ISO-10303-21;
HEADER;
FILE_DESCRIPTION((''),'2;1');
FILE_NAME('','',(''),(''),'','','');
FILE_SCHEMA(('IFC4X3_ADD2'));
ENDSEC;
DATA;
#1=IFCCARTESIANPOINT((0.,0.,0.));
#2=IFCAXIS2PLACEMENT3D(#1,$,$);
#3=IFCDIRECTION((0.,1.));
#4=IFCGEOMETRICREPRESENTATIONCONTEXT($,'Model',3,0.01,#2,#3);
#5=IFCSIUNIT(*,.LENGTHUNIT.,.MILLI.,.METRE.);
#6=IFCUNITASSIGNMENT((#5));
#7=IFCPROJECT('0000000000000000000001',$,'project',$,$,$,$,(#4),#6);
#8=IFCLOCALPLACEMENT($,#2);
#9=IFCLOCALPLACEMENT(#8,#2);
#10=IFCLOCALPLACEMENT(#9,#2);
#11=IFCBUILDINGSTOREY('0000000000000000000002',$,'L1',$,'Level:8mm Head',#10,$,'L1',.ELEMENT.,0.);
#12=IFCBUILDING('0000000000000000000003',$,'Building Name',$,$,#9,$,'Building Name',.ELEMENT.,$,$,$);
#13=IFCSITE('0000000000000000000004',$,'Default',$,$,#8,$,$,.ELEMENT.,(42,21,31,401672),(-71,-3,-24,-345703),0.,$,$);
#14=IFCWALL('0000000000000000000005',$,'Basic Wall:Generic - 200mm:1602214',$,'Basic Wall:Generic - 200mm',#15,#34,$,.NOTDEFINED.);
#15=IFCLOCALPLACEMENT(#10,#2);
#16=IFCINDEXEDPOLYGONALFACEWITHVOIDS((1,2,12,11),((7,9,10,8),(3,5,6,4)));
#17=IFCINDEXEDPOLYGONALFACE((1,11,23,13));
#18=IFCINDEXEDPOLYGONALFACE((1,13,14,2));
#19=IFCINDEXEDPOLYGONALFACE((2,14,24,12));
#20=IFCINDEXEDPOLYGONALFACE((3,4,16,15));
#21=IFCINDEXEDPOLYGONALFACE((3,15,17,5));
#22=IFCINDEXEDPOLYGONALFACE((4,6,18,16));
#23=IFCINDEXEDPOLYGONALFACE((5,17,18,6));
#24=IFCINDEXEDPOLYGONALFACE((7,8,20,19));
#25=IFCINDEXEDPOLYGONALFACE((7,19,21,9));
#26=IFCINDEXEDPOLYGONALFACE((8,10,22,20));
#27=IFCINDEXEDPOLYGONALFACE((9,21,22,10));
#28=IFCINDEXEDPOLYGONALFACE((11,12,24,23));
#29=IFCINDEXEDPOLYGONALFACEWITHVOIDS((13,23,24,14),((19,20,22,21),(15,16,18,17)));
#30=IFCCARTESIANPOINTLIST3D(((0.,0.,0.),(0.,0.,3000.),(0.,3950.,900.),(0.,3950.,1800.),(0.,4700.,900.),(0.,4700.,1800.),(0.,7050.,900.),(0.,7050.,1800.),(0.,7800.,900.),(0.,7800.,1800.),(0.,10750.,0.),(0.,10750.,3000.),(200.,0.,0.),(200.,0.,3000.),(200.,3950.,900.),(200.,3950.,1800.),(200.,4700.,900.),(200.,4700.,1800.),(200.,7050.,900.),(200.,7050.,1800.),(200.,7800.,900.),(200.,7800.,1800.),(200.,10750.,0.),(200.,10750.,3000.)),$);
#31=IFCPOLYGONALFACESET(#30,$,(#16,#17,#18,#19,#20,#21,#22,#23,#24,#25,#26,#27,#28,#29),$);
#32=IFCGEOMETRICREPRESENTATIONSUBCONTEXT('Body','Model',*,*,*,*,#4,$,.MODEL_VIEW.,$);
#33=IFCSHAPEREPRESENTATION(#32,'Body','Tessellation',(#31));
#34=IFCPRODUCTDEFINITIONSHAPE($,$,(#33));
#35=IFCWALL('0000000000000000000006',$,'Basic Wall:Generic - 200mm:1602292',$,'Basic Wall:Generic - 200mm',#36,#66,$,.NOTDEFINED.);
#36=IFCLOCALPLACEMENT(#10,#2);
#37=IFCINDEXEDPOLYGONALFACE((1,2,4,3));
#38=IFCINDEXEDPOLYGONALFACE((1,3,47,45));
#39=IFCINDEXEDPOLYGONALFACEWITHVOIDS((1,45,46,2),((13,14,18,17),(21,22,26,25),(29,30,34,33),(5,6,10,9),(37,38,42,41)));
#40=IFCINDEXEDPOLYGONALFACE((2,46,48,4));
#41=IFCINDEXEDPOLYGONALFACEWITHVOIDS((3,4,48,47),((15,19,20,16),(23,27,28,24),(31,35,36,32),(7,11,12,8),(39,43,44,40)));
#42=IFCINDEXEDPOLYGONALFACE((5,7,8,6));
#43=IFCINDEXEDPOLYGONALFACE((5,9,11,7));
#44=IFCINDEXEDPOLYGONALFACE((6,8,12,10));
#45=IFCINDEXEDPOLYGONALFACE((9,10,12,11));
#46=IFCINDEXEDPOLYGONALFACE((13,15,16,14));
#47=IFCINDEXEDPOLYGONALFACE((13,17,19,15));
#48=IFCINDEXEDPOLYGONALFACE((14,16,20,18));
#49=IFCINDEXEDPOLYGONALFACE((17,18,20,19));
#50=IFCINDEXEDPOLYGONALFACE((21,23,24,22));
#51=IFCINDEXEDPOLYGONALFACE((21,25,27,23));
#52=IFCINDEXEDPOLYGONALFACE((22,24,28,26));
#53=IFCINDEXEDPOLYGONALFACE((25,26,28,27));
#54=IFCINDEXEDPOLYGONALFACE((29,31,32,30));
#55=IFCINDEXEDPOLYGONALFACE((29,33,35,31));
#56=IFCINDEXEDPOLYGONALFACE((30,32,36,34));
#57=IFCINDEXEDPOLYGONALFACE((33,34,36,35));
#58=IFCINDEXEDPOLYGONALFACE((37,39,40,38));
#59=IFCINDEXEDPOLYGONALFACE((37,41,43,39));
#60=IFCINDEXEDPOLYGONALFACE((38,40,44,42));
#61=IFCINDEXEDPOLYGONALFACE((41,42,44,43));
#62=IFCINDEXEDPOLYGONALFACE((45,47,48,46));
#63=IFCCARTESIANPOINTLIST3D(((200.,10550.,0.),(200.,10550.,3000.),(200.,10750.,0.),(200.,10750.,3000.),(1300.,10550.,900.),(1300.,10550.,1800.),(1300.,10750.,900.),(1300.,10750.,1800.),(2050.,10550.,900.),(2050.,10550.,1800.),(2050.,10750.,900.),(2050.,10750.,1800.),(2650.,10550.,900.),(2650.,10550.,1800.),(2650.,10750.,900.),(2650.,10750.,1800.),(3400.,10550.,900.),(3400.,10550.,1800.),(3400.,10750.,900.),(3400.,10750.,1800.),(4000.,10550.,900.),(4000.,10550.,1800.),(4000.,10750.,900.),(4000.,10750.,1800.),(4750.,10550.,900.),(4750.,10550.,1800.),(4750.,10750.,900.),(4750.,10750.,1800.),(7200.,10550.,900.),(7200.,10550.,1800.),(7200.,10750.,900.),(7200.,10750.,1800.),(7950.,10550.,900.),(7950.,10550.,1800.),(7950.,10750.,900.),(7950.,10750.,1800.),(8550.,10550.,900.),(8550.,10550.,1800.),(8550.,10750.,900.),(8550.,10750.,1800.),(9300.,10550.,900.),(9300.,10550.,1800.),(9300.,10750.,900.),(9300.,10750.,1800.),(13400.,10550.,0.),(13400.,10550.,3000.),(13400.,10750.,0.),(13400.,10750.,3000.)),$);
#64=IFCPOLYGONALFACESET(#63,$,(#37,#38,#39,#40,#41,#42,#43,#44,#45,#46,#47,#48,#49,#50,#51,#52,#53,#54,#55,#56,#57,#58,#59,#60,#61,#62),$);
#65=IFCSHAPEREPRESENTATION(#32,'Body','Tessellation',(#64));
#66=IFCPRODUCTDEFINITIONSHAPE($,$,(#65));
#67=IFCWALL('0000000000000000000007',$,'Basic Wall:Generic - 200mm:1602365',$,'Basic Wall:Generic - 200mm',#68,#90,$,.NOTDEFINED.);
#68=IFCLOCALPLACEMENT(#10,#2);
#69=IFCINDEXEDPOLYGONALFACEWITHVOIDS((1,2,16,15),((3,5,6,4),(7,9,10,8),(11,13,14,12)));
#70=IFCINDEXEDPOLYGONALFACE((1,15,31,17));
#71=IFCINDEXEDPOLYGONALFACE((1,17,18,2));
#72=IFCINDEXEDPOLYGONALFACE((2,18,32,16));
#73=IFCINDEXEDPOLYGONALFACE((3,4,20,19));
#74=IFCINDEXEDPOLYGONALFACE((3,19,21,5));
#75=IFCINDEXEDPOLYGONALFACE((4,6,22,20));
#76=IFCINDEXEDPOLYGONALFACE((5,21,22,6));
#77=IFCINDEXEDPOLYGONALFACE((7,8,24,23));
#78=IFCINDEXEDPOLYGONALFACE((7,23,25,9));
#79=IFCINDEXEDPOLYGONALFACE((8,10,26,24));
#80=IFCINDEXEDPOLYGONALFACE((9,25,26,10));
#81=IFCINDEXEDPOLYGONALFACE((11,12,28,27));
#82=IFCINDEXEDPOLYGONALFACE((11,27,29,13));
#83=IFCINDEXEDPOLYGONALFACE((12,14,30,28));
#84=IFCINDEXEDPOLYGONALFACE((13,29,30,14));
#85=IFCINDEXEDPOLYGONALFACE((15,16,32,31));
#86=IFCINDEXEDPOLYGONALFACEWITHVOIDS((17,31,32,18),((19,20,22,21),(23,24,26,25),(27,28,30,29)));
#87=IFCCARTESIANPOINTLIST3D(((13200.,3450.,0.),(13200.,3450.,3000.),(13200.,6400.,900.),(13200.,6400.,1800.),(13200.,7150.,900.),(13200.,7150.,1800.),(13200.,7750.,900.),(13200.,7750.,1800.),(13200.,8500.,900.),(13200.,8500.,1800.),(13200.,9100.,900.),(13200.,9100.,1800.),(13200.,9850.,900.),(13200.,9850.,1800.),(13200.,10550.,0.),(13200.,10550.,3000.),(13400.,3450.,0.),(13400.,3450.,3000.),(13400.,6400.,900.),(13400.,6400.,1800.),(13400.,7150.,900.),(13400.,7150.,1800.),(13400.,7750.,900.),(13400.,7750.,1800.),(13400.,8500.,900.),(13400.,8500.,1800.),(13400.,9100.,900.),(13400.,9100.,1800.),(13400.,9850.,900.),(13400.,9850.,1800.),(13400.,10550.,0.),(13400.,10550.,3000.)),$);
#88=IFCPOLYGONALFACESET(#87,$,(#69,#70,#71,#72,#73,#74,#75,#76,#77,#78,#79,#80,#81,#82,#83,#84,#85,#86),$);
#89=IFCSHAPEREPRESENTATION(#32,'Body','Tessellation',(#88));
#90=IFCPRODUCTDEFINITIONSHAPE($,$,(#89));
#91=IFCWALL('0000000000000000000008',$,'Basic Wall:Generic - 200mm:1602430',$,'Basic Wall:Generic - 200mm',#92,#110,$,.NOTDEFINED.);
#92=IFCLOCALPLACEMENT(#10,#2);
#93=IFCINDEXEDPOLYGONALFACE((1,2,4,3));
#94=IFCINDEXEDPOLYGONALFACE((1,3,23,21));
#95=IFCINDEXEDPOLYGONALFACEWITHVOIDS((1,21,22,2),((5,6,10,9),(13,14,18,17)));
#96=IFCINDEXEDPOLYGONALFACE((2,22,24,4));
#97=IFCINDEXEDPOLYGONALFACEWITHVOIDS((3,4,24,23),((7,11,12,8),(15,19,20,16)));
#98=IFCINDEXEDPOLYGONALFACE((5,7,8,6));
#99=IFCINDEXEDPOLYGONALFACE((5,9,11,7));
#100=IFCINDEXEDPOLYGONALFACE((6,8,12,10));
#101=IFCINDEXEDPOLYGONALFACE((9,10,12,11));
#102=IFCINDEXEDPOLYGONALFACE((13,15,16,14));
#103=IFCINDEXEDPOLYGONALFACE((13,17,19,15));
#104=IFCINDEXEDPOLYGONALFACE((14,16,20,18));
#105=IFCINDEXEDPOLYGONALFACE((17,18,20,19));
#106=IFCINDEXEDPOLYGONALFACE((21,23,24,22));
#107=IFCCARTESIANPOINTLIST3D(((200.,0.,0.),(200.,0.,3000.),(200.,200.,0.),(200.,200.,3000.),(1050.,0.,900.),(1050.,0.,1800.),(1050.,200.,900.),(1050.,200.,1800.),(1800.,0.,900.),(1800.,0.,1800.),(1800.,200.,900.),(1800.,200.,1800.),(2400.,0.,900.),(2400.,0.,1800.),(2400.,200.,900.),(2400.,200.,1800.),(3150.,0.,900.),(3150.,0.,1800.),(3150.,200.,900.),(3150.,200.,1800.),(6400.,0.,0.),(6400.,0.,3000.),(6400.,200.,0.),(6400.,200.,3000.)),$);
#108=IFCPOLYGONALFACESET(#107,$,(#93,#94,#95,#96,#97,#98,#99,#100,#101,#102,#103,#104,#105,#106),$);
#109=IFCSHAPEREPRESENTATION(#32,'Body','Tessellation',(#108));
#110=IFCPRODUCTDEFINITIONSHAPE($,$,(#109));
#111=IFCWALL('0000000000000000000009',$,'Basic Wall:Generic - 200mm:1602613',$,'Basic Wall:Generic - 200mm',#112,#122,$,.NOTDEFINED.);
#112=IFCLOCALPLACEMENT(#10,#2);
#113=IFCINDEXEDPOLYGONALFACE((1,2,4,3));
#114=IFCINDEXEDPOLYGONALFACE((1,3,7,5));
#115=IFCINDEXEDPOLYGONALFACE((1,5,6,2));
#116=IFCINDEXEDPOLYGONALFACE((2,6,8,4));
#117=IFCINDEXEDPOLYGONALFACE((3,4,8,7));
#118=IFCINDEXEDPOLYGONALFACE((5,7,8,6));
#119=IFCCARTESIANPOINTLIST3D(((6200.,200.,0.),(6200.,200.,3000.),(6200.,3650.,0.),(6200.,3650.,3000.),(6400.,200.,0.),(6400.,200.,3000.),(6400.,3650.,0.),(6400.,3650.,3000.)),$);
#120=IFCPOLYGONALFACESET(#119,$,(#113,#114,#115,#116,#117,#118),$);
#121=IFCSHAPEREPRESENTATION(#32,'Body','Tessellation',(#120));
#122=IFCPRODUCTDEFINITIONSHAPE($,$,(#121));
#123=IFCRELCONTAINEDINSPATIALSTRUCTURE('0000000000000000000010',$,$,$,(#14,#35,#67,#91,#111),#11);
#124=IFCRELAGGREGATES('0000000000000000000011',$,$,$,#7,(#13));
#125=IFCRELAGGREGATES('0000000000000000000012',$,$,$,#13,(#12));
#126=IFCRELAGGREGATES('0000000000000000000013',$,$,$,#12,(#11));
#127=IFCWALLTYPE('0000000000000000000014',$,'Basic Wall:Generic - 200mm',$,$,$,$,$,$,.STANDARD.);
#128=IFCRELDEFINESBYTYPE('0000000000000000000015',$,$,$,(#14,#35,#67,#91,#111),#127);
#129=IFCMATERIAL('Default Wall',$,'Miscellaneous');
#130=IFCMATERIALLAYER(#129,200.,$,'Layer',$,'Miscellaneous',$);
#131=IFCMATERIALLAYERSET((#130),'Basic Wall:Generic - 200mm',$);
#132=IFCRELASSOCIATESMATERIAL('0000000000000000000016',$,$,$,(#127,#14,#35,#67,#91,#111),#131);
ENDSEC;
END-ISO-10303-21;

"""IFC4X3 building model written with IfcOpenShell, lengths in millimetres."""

from ifc_helpers import new_model, si_unit, direction, frame, frame_2d, origin, place, context, subcontext, project, spatial, rectangle, extrude, material, layer, layer_set, type_object, element, save


model = new_model("IFC4X3")

# Units and contexts
model_context = context("Model", 3, precision=0.01, world=origin(), true_north=direction((0.0, 1.0)))
body_context = subcontext(model_context, "Body", "Model", "MODEL_VIEW")
ifc_project = project(units=[si_unit("LENGTHUNIT", "METRE", prefix="MILLI")], contexts=[model_context])

# Site, building, storey
site_placement = place(None, origin())
site = spatial("IfcSite", under=ifc_project, at=site_placement, Name="Default", CompositionType="ELEMENT", RefLatitude=(42, 21, 31, 401672), RefLongitude=(-71, -3, -24, -345703), RefElevation=0.0)
building_placement = place(site_placement, origin())
building = spatial("IfcBuilding", under=site, at=building_placement, Name="Building Name", LongName="Building Name", CompositionType="ELEMENT")
storey_placement = place(building_placement, origin())
storey = spatial("IfcBuildingStorey", under=building, at=storey_placement, Name="L1", ObjectType="Level:8mm Head", LongName="L1", CompositionType="ELEMENT", Elevation=0.0)

# Walls, openings
ifc_material = material(Name="Default Wall", Category="Miscellaneous")
ifc_layer = layer(ifc_material, 200.0, Name="Layer", Category="Miscellaneous")
ifc_layer_set = layer_set([ifc_layer], Name="Basic Wall:Generic - 200mm")
wall_type = type_object("IfcWallType", Name="Basic Wall:Generic - 200mm", PredefinedType="STANDARD", material=ifc_layer_set)
wall_1_placement = place(storey_placement, frame((100.0, 0.0, 0.0), z_axis=(0.0, 0.0, 1.0), x_axis=(0.0, 1.0, 0.0)))
wall_1 = element("IfcWall", 1, at=wall_1_placement, inside=storey, type_object=wall_type, material=ifc_layer_set, Name="Basic Wall:Generic - 200mm:1602214", ObjectType="Basic Wall:Generic - 200mm", PredefinedType="NOTDEFINED", context=body_context, shape_type="SweptSolid", body=[
    extrude(rectangle(XDim=10750.0, YDim=200.0, at=frame_2d((5375.0, 0.0), x_axis=(-1.0, 0.0))), origin(), (0.0, 0.0, 1.0), 3000.0),
])
opening_1_placement = place(wall_1_placement, frame((3950.0, -100.0, 900.0)))
element("IfcOpeningElement", 2, at=opening_1_placement, cuts=wall_1, PredefinedType="OPENING", context=body_context, shape_type="SweptSolid", body=[
    extrude(rectangle(XDim=900.0, YDim=750.0, at=frame_2d((450.0, 375.0), x_axis=(-1.0, 0.0))), frame((0.0, 0.0, 0.0), z_axis=(0.0, 1.0, 0.0), x_axis=(0.0, 0.0, 1.0)), (0.0, 0.0, 1.0), 200.0),
])
opening_2_placement = place(wall_1_placement, frame((7050.0, -100.0, 900.0)))
element("IfcOpeningElement", 3, at=opening_2_placement, cuts=wall_1, PredefinedType="OPENING", context=body_context, shape_type="SweptSolid", body=[
    extrude(rectangle(XDim=900.0, YDim=750.0, at=frame_2d((450.0, 375.0), x_axis=(-1.0, 0.0))), frame((0.0, 0.0, 0.0), z_axis=(0.0, 1.0, 0.0), x_axis=(0.0, 0.0, 1.0)), (0.0, 0.0, 1.0), 200.0),
])
wall_2_placement = place(storey_placement, frame((200.0, 10650.0, 0.0)))
wall_2 = element("IfcWall", 4, at=wall_2_placement, inside=storey, type_object=wall_type, material=ifc_layer_set, Name="Basic Wall:Generic - 200mm:1602292", ObjectType="Basic Wall:Generic - 200mm", PredefinedType="NOTDEFINED", context=body_context, shape_type="SweptSolid", body=[
    extrude(rectangle(XDim=13200.0, YDim=200.0, at=frame_2d((6600.0, 0.0), x_axis=(-1.0, 0.0))), origin(), (0.0, 0.0, 1.0), 3000.0),
])
opening_3_placement = place(wall_2_placement, frame((1100.0, -100.0, 900.0)))
element("IfcOpeningElement", 5, at=opening_3_placement, cuts=wall_2, PredefinedType="OPENING", context=body_context, shape_type="SweptSolid", body=[
    extrude(rectangle(XDim=900.0, YDim=750.0, at=frame_2d((450.0, 375.0), x_axis=(-1.0, 0.0))), frame((0.0, 0.0, 0.0), z_axis=(0.0, 1.0, 0.0), x_axis=(0.0, 0.0, 1.0)), (0.0, 0.0, 1.0), 200.0),
])
opening_4_placement = place(wall_2_placement, frame((2450.0, -100.0, 900.0)))
element("IfcOpeningElement", 6, at=opening_4_placement, cuts=wall_2, PredefinedType="OPENING", context=body_context, shape_type="SweptSolid", body=[
    extrude(rectangle(XDim=900.0, YDim=750.0, at=frame_2d((450.0, 375.0), x_axis=(-1.0, 0.0))), frame((0.0, 0.0, 0.0), z_axis=(0.0, 1.0, 0.0), x_axis=(0.0, 0.0, 1.0)), (0.0, 0.0, 1.0), 200.0),
])
opening_5_placement = place(wall_2_placement, frame((3800.0, -100.0, 900.0)))
element("IfcOpeningElement", 7, at=opening_5_placement, cuts=wall_2, PredefinedType="OPENING", context=body_context, shape_type="SweptSolid", body=[
    extrude(rectangle(XDim=900.0, YDim=750.0, at=frame_2d((450.0, 375.0), x_axis=(-1.0, 0.0))), frame((0.0, 0.0, 0.0), z_axis=(0.0, 1.0, 0.0), x_axis=(0.0, 0.0, 1.0)), (0.0, 0.0, 1.0), 200.0),
])
opening_6_placement = place(wall_2_placement, frame((7000.0, -100.0, 900.0)))
element("IfcOpeningElement", 8, at=opening_6_placement, cuts=wall_2, PredefinedType="OPENING", context=body_context, shape_type="SweptSolid", body=[
    extrude(rectangle(XDim=900.0, YDim=750.0, at=frame_2d((450.0, 375.0), x_axis=(-1.0, 0.0))), frame((0.0, 0.0, 0.0), z_axis=(0.0, 1.0, 0.0), x_axis=(0.0, 0.0, 1.0)), (0.0, 0.0, 1.0), 200.0),
])
opening_7_placement = place(wall_2_placement, frame((8350.0, -100.0, 900.0)))
element("IfcOpeningElement", 9, at=opening_7_placement, cuts=wall_2, PredefinedType="OPENING", context=body_context, shape_type="SweptSolid", body=[
    extrude(rectangle(XDim=900.0, YDim=750.0, at=frame_2d((450.0, 375.0), x_axis=(-1.0, 0.0))), frame((0.0, 0.0, 0.0), z_axis=(0.0, 1.0, 0.0), x_axis=(0.0, 0.0, 1.0)), (0.0, 0.0, 1.0), 200.0),
])
wall_3_placement = place(storey_placement, frame((13300.0, 10550.0, 0.0), z_axis=(0.0, 0.0, 1.0), x_axis=(0.0, -1.0, 0.0)))
wall_3 = element("IfcWall", 10, at=wall_3_placement, inside=storey, type_object=wall_type, material=ifc_layer_set, Name="Basic Wall:Generic - 200mm:1602365", ObjectType="Basic Wall:Generic - 200mm", PredefinedType="NOTDEFINED", context=body_context, shape_type="SweptSolid", body=[
    extrude(rectangle(XDim=7100.0, YDim=200.0, at=frame_2d((3550.0, 0.0), x_axis=(-1.0, 0.0))), origin(), (0.0, 0.0, 1.0), 3000.0),
])
opening_8_placement = place(wall_3_placement, frame((700.0, -100.0, 900.0)))
element("IfcOpeningElement", 11, at=opening_8_placement, cuts=wall_3, PredefinedType="OPENING", context=body_context, shape_type="SweptSolid", body=[
    extrude(rectangle(XDim=900.0, YDim=750.0, at=frame_2d((450.0, 375.0), x_axis=(-1.0, 0.0))), frame((0.0, 0.0, 0.0), z_axis=(0.0, 1.0, 0.0), x_axis=(0.0, 0.0, 1.0)), (0.0, 0.0, 1.0), 200.0),
])
opening_9_placement = place(wall_3_placement, frame((2050.0, -100.0, 900.0)))
element("IfcOpeningElement", 12, at=opening_9_placement, cuts=wall_3, PredefinedType="OPENING", context=body_context, shape_type="SweptSolid", body=[
    extrude(rectangle(XDim=900.0, YDim=750.0, at=frame_2d((450.0, 375.0), x_axis=(-1.0, 0.0))), frame((0.0, 0.0, 0.0), z_axis=(0.0, 1.0, 0.0), x_axis=(0.0, 0.0, 1.0)), (0.0, 0.0, 1.0), 200.0),
])
opening_10_placement = place(wall_3_placement, frame((3400.0, -100.0, 900.0)))
element("IfcOpeningElement", 13, at=opening_10_placement, cuts=wall_3, PredefinedType="OPENING", context=body_context, shape_type="SweptSolid", body=[
    extrude(rectangle(XDim=900.0, YDim=750.0, at=frame_2d((450.0, 375.0), x_axis=(-1.0, 0.0))), frame((0.0, 0.0, 0.0), z_axis=(0.0, 1.0, 0.0), x_axis=(0.0, 0.0, 1.0)), (0.0, 0.0, 1.0), 200.0),
])
wall_4_placement = place(storey_placement, frame((6400.0, 100.0, 0.0), z_axis=(0.0, 0.0, 1.0), x_axis=(-1.0, 0.0, 0.0)))
wall_4 = element("IfcWall", 14, at=wall_4_placement, inside=storey, type_object=wall_type, material=ifc_layer_set, Name="Basic Wall:Generic - 200mm:1602430", ObjectType="Basic Wall:Generic - 200mm", PredefinedType="NOTDEFINED", context=body_context, shape_type="SweptSolid", body=[
    extrude(rectangle(XDim=6200.0, YDim=200.0, at=frame_2d((3100.0, 0.0), x_axis=(-1.0, 0.0))), origin(), (0.0, 0.0, 1.0), 3000.0),
])
opening_11_placement = place(wall_4_placement, frame((3250.0, -100.0, 900.0)))
element("IfcOpeningElement", 15, at=opening_11_placement, cuts=wall_4, PredefinedType="OPENING", context=body_context, shape_type="SweptSolid", body=[
    extrude(rectangle(XDim=900.0, YDim=750.0, at=frame_2d((450.0, 375.0), x_axis=(-1.0, 0.0))), frame((0.0, 0.0, 0.0), z_axis=(0.0, 1.0, 0.0), x_axis=(0.0, 0.0, 1.0)), (0.0, 0.0, 1.0), 200.0),
])
opening_12_placement = place(wall_4_placement, frame((4600.0, -100.0, 900.0)))
element("IfcOpeningElement", 16, at=opening_12_placement, cuts=wall_4, PredefinedType="OPENING", context=body_context, shape_type="SweptSolid", body=[
    extrude(rectangle(XDim=900.0, YDim=750.0, at=frame_2d((450.0, 375.0), x_axis=(-1.0, 0.0))), frame((0.0, 0.0, 0.0), z_axis=(0.0, 1.0, 0.0), x_axis=(0.0, 0.0, 1.0)), (0.0, 0.0, 1.0), 200.0),
])

# Wall
wall_5_placement = place(storey_placement, frame((6300.0, 200.0, 0.0), z_axis=(0.0, 0.0, 1.0), x_axis=(0.0, 1.0, 0.0)))
element("IfcWall", 17, at=wall_5_placement, inside=storey, type_object=wall_type, material=ifc_layer_set, Name="Basic Wall:Generic - 200mm:1602613", ObjectType="Basic Wall:Generic - 200mm", PredefinedType="NOTDEFINED", context=body_context, shape_type="SweptSolid", body=[
    extrude(rectangle(XDim=3450.0, YDim=200.0, at=frame_2d((1725.0, 0.0), x_axis=(-1.0, 0.0))), origin(), (0.0, 0.0, 1.0), 3000.0),
])

save(model, "model.ifc")
